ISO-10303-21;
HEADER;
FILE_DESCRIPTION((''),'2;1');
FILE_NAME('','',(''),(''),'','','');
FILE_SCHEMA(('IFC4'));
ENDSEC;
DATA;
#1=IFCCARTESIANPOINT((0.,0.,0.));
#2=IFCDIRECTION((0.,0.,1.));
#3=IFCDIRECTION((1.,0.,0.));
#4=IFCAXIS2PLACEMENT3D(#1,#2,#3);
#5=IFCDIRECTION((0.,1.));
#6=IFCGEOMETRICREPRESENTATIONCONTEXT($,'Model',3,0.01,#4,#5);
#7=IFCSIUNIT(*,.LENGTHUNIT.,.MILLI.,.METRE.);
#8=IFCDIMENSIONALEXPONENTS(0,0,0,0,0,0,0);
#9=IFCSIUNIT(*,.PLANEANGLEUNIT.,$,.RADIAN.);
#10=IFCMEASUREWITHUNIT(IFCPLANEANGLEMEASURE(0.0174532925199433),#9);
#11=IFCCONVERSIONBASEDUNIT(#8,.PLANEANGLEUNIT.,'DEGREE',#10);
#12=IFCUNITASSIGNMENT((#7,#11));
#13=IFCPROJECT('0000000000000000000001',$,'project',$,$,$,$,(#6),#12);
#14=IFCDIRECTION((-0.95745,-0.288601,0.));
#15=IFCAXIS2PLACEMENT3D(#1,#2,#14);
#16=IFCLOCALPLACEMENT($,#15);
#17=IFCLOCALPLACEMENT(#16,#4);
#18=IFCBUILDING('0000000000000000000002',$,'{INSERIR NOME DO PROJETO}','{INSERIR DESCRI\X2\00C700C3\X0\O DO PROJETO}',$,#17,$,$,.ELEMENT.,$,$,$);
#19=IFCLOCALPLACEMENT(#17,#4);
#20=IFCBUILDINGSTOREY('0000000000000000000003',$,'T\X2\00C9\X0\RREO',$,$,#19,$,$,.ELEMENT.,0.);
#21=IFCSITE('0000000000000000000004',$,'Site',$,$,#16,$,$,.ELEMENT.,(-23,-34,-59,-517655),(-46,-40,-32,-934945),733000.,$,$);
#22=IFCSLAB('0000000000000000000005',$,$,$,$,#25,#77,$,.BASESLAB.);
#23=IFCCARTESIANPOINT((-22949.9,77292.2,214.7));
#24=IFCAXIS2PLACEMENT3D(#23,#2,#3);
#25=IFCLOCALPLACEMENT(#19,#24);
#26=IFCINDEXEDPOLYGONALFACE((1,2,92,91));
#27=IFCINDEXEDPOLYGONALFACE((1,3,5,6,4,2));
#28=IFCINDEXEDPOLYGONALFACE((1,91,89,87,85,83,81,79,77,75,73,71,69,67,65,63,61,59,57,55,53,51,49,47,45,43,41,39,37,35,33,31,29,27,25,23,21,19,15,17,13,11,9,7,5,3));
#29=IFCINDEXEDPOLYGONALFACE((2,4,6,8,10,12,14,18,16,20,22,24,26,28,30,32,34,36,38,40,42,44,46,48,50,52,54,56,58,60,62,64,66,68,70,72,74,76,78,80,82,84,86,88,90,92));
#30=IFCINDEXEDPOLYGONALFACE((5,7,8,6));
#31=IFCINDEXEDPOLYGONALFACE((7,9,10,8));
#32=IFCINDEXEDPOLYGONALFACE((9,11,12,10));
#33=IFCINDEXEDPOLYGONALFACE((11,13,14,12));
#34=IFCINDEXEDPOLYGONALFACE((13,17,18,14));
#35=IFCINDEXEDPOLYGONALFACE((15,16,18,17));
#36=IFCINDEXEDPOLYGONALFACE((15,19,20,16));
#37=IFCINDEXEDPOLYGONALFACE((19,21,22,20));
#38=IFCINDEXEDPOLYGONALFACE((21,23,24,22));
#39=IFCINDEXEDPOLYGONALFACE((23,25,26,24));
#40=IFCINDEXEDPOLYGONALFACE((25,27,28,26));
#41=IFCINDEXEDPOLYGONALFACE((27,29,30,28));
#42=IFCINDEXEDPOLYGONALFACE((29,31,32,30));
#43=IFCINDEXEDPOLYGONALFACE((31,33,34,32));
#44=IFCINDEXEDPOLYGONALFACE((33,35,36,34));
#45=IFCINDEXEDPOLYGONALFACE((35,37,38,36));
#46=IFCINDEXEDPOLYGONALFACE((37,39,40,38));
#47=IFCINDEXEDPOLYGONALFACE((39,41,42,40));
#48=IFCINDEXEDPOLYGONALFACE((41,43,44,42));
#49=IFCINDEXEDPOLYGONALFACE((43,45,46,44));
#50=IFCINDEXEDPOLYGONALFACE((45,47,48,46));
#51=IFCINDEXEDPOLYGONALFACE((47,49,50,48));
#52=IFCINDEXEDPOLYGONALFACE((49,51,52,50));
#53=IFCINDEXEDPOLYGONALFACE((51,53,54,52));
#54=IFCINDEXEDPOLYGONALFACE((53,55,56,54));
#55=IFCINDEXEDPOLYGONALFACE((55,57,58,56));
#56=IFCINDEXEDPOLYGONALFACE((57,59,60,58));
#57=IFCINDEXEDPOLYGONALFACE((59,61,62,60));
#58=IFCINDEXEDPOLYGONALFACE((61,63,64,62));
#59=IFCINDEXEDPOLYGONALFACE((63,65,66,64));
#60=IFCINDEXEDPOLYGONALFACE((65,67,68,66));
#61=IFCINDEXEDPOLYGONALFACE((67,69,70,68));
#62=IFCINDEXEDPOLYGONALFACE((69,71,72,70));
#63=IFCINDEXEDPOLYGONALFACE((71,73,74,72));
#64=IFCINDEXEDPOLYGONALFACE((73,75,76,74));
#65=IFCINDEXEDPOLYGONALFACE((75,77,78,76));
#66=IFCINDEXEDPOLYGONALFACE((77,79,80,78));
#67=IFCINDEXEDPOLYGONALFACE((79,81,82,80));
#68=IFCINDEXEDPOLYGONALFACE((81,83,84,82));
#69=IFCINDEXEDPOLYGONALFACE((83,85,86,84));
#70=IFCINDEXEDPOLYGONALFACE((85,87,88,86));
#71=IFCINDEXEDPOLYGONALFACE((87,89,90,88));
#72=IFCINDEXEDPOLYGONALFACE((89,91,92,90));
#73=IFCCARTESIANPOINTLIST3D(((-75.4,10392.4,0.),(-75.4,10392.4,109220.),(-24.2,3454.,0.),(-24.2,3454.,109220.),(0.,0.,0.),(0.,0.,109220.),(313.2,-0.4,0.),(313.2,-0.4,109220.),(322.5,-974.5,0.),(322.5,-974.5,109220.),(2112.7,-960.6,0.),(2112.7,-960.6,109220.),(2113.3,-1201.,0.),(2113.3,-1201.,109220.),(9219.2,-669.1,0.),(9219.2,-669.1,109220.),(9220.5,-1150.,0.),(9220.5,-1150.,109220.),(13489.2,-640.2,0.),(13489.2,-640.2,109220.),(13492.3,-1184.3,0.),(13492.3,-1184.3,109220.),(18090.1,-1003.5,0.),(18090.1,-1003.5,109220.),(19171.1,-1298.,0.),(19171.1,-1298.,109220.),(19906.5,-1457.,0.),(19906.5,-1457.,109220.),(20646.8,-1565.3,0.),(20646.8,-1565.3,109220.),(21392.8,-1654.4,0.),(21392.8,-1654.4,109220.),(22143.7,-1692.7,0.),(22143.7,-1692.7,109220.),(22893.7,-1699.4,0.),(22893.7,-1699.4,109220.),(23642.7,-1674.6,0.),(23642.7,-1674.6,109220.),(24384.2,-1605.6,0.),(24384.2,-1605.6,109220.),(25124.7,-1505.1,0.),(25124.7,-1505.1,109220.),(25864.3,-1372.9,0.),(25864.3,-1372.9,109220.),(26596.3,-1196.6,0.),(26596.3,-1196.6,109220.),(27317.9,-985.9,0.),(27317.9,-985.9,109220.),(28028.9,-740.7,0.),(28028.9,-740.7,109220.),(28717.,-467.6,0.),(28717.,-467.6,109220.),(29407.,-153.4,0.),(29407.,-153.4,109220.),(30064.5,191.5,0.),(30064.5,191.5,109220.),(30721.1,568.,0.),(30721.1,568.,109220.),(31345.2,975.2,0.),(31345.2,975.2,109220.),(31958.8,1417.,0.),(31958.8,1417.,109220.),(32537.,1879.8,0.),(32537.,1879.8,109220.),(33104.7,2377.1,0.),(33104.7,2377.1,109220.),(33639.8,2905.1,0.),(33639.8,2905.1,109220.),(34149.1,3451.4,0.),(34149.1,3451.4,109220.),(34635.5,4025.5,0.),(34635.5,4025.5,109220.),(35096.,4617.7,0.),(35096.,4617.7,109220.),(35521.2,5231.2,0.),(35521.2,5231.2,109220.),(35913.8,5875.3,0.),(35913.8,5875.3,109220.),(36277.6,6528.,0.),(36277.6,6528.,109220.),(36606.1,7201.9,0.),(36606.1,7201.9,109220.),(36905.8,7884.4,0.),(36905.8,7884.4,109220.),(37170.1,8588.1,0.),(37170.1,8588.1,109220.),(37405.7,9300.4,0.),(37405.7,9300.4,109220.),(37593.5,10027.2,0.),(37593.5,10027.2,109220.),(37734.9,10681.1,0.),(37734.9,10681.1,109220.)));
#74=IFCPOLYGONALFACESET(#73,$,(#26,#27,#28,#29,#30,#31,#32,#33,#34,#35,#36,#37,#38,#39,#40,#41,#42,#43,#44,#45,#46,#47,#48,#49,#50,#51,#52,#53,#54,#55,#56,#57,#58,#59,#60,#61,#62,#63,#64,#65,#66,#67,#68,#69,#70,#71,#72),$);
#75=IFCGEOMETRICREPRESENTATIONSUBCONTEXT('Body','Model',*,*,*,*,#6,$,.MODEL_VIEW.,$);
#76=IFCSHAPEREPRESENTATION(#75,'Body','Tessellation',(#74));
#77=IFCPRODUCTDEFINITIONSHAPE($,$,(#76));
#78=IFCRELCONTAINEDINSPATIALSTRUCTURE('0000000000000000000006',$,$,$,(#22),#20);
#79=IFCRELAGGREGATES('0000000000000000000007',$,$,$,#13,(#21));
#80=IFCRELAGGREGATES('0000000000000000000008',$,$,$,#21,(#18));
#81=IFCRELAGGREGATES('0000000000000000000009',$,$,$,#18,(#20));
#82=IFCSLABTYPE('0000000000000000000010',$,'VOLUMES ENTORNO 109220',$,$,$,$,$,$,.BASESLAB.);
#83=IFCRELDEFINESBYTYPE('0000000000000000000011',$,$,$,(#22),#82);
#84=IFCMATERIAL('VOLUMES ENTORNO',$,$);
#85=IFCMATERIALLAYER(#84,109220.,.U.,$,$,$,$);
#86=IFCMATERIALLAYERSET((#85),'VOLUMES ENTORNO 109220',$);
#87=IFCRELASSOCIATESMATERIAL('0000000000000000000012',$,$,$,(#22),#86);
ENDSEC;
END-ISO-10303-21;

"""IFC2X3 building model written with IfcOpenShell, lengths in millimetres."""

from ifc_helpers import new_model, entity, si_unit, converted_unit, direction, frame, origin_with_axes, place, context, subcontext, project, spatial, polyline, outline, extrude, material, layer, layer_set, layer_usage, type_object, element, save


model = new_model("IFC2X3")

# Units and contexts
model_context = context("Model", 3, precision=0.01, world=origin_with_axes(), true_north=direction((0.0, 1.0)))
body_context = subcontext(model_context, "Body", "Model", "MODEL_VIEW")
ifc_project = project(units=[si_unit("LENGTHUNIT", "METRE", prefix="MILLI"), converted_unit("PLANEANGLEUNIT", "DEGREE", entity("IfcPlaneAngleMeasure", 0.0174532925199433), si_unit("PLANEANGLEUNIT", "RADIAN"), dimensions=[0, 0, 0, 0, 0, 0, 0])], contexts=[model_context])

# Site, building, storey
site_placement = place(None, frame((0.0, 0.0, 0.0), z_axis=(0.0, 0.0, 1.0), x_axis=(-0.95745, -0.288601, 0.0)))
site = spatial("IfcSite", under=ifc_project, at=site_placement, Name="Site", CompositionType="ELEMENT", RefLatitude=(-23, -34, -59, -517655), RefLongitude=(-46, -40, -32, -934945), RefElevation=733000.0)
building_placement = place(site_placement, origin_with_axes())
building = spatial("IfcBuilding", under=site, at=building_placement, Name="{INSERIR NOME DO PROJETO}", Description="{INSERIR DESCRIÇÃO DO PROJETO}", CompositionType="ELEMENT")
storey_placement = place(building_placement, origin_with_axes())
storey = spatial("IfcBuildingStorey", under=building, at=storey_placement, Name="TÉRREO", CompositionType="ELEMENT", Elevation=0.0)

# Slab
ifc_material_1 = material(Name="VOLUMES ENTORNO")
ifc_layer_1 = layer(ifc_material_1, 109220.0, ventilated="UNKNOWN")
ifc_layer_set_1 = layer_set([ifc_layer_1], Name="VOLUMES ENTORNO 109220")
ifc_layer_usage_1 = layer_usage(ifc_layer_set_1, "AXIS3", "NEGATIVE", 109220.0)
slab_type_1 = type_object("IfcSlabType", Name="VOLUMES ENTORNO 109220", PredefinedType="BASESLAB")
slab_1_placement = place(storey_placement, frame((-22949.9, 77292.2, 214.7), z_axis=(0.0, 0.0, 1.0), x_axis=(1.0, 0.0, 0.0)))
element("IfcSlab", 1, at=slab_1_placement, inside=storey, type_object=slab_type_1, material=ifc_layer_usage_1, PredefinedType="BASESLAB", context=body_context, shape_type="SweptSolid", body=[
    extrude(outline(polyline([(0.0, 0.0), (313.2, -0.4), (322.5, -974.5), (2112.7, -960.6), (2113.3, -1201.0), (9220.5, -1150.0), (9219.2, -669.1), (13489.2, -640.2), (13492.3, -1184.3), (18090.1, -1003.5), (19171.1, -1298.0), (19906.5, -1457.0), (20646.8, -1565.3), (21392.8, -1654.4), (22143.7, -1692.7), (22893.7, -1699.4), (23642.7, -1674.6), (24384.2, -1605.6), (25124.7, -1505.1), (25864.3, -1372.9), (26596.3, -1196.6), (27317.9, -985.9), (28028.9, -740.7), (28717.0, -467.6), (29407.0, -153.4), (30064.5, 191.5), (30721.1, 568.0), (31345.2, 975.2), (31958.8, 1417.0), (32537.0, 1879.8), (33104.7, 2377.1), (33639.8, 2905.1), (34149.1, 3451.4), (34635.5, 4025.5), (35096.0, 4617.7), (35521.2, 5231.2), (35913.8, 5875.3), (36277.6, 6528.0), (36606.1, 7201.9), (36905.8, 7884.4), (37170.1, 8588.1), (37405.7, 9300.4), (37593.5, 10027.2), (37734.9, 10681.1), (-75.4, 10392.4), (-24.2, 3454.0), (0.0, 0.0)])), origin_with_axes(), (0.0, 0.0, 1.0), 109220.0),
])

save(model, "model.ifc")
